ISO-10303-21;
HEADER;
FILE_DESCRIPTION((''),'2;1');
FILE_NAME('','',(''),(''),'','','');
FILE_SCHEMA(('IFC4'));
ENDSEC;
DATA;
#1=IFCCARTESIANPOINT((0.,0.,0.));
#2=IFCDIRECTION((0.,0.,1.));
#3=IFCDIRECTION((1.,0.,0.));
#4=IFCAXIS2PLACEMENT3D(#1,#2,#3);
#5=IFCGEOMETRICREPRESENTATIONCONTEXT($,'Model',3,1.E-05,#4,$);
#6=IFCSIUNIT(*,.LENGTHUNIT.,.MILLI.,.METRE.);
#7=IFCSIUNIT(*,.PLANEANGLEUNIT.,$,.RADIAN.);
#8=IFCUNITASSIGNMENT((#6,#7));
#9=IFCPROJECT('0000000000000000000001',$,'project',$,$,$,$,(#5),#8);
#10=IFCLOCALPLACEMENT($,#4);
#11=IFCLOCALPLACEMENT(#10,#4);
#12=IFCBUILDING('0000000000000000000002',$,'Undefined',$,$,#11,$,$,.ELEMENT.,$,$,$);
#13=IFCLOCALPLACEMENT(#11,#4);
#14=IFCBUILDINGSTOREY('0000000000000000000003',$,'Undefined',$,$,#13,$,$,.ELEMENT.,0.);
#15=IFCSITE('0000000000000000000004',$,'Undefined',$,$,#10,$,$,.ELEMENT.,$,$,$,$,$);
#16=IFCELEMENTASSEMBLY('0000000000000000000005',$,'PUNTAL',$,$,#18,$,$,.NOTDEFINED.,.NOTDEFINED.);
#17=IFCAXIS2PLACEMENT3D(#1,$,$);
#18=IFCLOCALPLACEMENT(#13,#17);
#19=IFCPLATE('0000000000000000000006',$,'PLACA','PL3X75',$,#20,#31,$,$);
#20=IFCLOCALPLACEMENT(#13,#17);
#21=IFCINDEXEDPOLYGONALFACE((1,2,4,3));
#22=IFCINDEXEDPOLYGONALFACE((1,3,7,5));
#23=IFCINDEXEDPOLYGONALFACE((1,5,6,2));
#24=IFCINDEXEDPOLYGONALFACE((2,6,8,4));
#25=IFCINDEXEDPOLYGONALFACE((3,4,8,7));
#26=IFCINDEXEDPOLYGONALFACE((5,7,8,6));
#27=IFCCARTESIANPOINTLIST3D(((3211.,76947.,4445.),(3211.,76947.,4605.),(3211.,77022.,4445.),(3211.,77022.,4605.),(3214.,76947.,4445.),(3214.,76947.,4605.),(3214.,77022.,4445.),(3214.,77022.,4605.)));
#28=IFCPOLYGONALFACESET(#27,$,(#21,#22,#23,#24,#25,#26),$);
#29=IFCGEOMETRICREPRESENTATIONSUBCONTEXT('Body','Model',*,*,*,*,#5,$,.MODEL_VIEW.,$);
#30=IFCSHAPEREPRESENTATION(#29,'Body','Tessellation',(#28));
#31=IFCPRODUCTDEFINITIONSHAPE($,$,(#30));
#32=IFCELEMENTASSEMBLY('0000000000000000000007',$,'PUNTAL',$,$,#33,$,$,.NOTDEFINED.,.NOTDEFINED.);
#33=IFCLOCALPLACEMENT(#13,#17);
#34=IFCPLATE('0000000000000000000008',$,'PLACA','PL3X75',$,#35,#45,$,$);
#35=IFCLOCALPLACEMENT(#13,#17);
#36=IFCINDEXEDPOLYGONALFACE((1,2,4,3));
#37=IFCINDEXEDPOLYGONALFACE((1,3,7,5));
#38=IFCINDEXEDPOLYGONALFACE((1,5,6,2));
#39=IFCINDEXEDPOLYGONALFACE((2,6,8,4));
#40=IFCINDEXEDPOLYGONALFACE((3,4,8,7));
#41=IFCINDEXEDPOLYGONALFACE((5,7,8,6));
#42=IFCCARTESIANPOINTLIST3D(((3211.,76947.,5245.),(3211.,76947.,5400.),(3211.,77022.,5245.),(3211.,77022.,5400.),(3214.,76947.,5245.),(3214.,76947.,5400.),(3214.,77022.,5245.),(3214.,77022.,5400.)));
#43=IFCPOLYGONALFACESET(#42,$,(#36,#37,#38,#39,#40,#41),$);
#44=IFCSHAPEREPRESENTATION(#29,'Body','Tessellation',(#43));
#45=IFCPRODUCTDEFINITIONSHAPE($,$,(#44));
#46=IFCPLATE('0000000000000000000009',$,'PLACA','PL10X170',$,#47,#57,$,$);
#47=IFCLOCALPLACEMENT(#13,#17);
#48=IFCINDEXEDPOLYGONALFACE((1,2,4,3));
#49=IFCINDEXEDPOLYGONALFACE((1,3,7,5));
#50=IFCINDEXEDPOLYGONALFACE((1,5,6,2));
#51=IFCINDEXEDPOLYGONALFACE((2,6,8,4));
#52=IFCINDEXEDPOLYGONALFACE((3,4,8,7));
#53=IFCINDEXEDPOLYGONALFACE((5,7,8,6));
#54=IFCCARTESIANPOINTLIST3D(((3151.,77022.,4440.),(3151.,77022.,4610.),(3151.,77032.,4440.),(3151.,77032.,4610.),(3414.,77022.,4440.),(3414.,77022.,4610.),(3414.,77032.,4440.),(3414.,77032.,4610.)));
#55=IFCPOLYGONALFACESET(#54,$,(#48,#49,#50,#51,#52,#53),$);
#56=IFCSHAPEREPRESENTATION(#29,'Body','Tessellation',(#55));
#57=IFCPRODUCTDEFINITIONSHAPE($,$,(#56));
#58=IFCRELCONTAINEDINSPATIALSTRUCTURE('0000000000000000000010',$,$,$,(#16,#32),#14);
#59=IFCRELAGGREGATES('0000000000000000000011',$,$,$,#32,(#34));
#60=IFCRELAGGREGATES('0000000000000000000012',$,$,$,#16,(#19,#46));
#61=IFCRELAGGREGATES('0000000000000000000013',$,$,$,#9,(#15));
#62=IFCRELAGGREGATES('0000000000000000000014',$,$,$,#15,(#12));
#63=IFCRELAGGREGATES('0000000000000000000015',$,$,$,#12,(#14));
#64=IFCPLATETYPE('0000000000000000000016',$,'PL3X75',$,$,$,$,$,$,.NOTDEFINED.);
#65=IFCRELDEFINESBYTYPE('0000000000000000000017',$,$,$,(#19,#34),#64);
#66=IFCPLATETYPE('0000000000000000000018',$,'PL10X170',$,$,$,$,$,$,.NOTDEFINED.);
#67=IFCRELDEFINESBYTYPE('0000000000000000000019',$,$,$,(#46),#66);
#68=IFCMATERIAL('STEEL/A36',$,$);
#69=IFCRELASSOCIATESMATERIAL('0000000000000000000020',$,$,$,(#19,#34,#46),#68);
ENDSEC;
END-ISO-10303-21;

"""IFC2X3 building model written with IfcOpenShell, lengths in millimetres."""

from ifc_helpers import new_model, si_unit, frame, origin_with_axes, place, context, subcontext, project, spatial, polyline, outline, extrude, material, type_object, element, aggregate, save


model = new_model("IFC2X3")

# Units and contexts
model_context = context("Model", 3, precision=1e-05, world=origin_with_axes())
body_context = subcontext(model_context, "Body", "Model", "MODEL_VIEW")
ifc_project = project(units=[si_unit("LENGTHUNIT", "METRE", prefix="MILLI"), si_unit("PLANEANGLEUNIT", "RADIAN")], contexts=[model_context])

# Site, building, storey
site_placement = place(None, origin_with_axes())
site = spatial("IfcSite", under=ifc_project, at=site_placement, Name="Undefined", CompositionType="ELEMENT")
building_placement = place(site_placement, origin_with_axes())
building = spatial("IfcBuilding", under=site, at=building_placement, Name="Undefined", CompositionType="ELEMENT")
storey_placement = place(building_placement, origin_with_axes())
storey = spatial("IfcBuildingStorey", under=building, at=storey_placement, Name="Undefined", CompositionType="ELEMENT", Elevation=0.0)

# Shared definitions
ifc_material_1 = material(Name="STEEL/A36")

# Element assemblies, plates
assembly_1_placement = place(storey_placement, origin_with_axes())
assembly_1 = element("IfcElementAssembly", 1, at=assembly_1_placement, inside=storey, Name="PUNTAL", AssemblyPlace="NOTDEFINED", PredefinedType="NOTDEFINED")
plate_type_1 = type_object("IfcPlateType", Name="PL3X75", PredefinedType="NOTDEFINED")
plate_1_placement = place(assembly_1_placement, frame((3212.5, 77022.0, 4605.0), z_axis=(1.0, 0.0, 0.0), x_axis=(0.0, -1.0, 0.0)))
plate_1 = element("IfcPlate", 2, at=plate_1_placement, type_object=plate_type_1, material=ifc_material_1, Name="PLACA", Description="PL3X75", context=body_context, shape_type="SweptSolid", body=[
    extrude(outline(polyline([(0.0, 0.0), (75.0, 0.0), (75.0, 160.0), (0.0, 160.0), (0.0, 0.0)])), frame((0.0, 0.0, -1.5), z_axis=(0.0, 0.0, 1.0), x_axis=(1.0, 0.0, 0.0)), (0.0, 0.0, 1.0), 3.0),
])
assembly_2_placement = place(storey_placement, origin_with_axes())
assembly_2 = element("IfcElementAssembly", 3, at=assembly_2_placement, inside=storey, Name="PUNTAL", AssemblyPlace="NOTDEFINED", PredefinedType="NOTDEFINED")
plate_2_placement = place(assembly_2_placement, frame((3212.5, 76947.0, 5245.0), z_axis=(1.0, 0.0, 0.0), x_axis=(0.0, 1.0, 0.0)))
plate_2 = element("IfcPlate", 4, at=plate_2_placement, type_object=plate_type_1, material=ifc_material_1, Name="PLACA", Description="PL3X75", context=body_context, shape_type="SweptSolid", body=[
    extrude(outline(polyline([(0.0, 0.0), (75.0, 0.0), (75.0, 155.0), (0.0, 155.0), (0.0, 0.0)])), frame((0.0, 0.0, -1.5), z_axis=(0.0, 0.0, 1.0), x_axis=(1.0, 0.0, 0.0)), (0.0, 0.0, 1.0), 3.0),
])
aggregate(assembly_2, [plate_2])

# Plate
plate_type_2 = type_object("IfcPlateType", Name="PL10X170", PredefinedType="NOTDEFINED")
plate_3_placement = place(assembly_1_placement, frame((3151.0, 77027.0, 4525.0), z_axis=(0.0, -1.0, 0.0), x_axis=(1.0, 0.0, 0.0)))
plate_3 = element("IfcPlate", 5, at=plate_3_placement, type_object=plate_type_2, material=ifc_material_1, Name="PLACA", Description="PL10X170", context=body_context, shape_type="SweptSolid", body=[
    extrude(outline(polyline([(0.0, -85.0), (0.0, 85.0), (263.0, 85.0), (263.0, -85.0), (0.0, -85.0)])), frame((0.0, 0.0, -5.0), z_axis=(0.0, 0.0, 1.0), x_axis=(1.0, 0.0, 0.0)), (0.0, 0.0, 1.0), 10.0),
])
aggregate(assembly_1, [plate_1, plate_3])

save(model, "model.ifc")
